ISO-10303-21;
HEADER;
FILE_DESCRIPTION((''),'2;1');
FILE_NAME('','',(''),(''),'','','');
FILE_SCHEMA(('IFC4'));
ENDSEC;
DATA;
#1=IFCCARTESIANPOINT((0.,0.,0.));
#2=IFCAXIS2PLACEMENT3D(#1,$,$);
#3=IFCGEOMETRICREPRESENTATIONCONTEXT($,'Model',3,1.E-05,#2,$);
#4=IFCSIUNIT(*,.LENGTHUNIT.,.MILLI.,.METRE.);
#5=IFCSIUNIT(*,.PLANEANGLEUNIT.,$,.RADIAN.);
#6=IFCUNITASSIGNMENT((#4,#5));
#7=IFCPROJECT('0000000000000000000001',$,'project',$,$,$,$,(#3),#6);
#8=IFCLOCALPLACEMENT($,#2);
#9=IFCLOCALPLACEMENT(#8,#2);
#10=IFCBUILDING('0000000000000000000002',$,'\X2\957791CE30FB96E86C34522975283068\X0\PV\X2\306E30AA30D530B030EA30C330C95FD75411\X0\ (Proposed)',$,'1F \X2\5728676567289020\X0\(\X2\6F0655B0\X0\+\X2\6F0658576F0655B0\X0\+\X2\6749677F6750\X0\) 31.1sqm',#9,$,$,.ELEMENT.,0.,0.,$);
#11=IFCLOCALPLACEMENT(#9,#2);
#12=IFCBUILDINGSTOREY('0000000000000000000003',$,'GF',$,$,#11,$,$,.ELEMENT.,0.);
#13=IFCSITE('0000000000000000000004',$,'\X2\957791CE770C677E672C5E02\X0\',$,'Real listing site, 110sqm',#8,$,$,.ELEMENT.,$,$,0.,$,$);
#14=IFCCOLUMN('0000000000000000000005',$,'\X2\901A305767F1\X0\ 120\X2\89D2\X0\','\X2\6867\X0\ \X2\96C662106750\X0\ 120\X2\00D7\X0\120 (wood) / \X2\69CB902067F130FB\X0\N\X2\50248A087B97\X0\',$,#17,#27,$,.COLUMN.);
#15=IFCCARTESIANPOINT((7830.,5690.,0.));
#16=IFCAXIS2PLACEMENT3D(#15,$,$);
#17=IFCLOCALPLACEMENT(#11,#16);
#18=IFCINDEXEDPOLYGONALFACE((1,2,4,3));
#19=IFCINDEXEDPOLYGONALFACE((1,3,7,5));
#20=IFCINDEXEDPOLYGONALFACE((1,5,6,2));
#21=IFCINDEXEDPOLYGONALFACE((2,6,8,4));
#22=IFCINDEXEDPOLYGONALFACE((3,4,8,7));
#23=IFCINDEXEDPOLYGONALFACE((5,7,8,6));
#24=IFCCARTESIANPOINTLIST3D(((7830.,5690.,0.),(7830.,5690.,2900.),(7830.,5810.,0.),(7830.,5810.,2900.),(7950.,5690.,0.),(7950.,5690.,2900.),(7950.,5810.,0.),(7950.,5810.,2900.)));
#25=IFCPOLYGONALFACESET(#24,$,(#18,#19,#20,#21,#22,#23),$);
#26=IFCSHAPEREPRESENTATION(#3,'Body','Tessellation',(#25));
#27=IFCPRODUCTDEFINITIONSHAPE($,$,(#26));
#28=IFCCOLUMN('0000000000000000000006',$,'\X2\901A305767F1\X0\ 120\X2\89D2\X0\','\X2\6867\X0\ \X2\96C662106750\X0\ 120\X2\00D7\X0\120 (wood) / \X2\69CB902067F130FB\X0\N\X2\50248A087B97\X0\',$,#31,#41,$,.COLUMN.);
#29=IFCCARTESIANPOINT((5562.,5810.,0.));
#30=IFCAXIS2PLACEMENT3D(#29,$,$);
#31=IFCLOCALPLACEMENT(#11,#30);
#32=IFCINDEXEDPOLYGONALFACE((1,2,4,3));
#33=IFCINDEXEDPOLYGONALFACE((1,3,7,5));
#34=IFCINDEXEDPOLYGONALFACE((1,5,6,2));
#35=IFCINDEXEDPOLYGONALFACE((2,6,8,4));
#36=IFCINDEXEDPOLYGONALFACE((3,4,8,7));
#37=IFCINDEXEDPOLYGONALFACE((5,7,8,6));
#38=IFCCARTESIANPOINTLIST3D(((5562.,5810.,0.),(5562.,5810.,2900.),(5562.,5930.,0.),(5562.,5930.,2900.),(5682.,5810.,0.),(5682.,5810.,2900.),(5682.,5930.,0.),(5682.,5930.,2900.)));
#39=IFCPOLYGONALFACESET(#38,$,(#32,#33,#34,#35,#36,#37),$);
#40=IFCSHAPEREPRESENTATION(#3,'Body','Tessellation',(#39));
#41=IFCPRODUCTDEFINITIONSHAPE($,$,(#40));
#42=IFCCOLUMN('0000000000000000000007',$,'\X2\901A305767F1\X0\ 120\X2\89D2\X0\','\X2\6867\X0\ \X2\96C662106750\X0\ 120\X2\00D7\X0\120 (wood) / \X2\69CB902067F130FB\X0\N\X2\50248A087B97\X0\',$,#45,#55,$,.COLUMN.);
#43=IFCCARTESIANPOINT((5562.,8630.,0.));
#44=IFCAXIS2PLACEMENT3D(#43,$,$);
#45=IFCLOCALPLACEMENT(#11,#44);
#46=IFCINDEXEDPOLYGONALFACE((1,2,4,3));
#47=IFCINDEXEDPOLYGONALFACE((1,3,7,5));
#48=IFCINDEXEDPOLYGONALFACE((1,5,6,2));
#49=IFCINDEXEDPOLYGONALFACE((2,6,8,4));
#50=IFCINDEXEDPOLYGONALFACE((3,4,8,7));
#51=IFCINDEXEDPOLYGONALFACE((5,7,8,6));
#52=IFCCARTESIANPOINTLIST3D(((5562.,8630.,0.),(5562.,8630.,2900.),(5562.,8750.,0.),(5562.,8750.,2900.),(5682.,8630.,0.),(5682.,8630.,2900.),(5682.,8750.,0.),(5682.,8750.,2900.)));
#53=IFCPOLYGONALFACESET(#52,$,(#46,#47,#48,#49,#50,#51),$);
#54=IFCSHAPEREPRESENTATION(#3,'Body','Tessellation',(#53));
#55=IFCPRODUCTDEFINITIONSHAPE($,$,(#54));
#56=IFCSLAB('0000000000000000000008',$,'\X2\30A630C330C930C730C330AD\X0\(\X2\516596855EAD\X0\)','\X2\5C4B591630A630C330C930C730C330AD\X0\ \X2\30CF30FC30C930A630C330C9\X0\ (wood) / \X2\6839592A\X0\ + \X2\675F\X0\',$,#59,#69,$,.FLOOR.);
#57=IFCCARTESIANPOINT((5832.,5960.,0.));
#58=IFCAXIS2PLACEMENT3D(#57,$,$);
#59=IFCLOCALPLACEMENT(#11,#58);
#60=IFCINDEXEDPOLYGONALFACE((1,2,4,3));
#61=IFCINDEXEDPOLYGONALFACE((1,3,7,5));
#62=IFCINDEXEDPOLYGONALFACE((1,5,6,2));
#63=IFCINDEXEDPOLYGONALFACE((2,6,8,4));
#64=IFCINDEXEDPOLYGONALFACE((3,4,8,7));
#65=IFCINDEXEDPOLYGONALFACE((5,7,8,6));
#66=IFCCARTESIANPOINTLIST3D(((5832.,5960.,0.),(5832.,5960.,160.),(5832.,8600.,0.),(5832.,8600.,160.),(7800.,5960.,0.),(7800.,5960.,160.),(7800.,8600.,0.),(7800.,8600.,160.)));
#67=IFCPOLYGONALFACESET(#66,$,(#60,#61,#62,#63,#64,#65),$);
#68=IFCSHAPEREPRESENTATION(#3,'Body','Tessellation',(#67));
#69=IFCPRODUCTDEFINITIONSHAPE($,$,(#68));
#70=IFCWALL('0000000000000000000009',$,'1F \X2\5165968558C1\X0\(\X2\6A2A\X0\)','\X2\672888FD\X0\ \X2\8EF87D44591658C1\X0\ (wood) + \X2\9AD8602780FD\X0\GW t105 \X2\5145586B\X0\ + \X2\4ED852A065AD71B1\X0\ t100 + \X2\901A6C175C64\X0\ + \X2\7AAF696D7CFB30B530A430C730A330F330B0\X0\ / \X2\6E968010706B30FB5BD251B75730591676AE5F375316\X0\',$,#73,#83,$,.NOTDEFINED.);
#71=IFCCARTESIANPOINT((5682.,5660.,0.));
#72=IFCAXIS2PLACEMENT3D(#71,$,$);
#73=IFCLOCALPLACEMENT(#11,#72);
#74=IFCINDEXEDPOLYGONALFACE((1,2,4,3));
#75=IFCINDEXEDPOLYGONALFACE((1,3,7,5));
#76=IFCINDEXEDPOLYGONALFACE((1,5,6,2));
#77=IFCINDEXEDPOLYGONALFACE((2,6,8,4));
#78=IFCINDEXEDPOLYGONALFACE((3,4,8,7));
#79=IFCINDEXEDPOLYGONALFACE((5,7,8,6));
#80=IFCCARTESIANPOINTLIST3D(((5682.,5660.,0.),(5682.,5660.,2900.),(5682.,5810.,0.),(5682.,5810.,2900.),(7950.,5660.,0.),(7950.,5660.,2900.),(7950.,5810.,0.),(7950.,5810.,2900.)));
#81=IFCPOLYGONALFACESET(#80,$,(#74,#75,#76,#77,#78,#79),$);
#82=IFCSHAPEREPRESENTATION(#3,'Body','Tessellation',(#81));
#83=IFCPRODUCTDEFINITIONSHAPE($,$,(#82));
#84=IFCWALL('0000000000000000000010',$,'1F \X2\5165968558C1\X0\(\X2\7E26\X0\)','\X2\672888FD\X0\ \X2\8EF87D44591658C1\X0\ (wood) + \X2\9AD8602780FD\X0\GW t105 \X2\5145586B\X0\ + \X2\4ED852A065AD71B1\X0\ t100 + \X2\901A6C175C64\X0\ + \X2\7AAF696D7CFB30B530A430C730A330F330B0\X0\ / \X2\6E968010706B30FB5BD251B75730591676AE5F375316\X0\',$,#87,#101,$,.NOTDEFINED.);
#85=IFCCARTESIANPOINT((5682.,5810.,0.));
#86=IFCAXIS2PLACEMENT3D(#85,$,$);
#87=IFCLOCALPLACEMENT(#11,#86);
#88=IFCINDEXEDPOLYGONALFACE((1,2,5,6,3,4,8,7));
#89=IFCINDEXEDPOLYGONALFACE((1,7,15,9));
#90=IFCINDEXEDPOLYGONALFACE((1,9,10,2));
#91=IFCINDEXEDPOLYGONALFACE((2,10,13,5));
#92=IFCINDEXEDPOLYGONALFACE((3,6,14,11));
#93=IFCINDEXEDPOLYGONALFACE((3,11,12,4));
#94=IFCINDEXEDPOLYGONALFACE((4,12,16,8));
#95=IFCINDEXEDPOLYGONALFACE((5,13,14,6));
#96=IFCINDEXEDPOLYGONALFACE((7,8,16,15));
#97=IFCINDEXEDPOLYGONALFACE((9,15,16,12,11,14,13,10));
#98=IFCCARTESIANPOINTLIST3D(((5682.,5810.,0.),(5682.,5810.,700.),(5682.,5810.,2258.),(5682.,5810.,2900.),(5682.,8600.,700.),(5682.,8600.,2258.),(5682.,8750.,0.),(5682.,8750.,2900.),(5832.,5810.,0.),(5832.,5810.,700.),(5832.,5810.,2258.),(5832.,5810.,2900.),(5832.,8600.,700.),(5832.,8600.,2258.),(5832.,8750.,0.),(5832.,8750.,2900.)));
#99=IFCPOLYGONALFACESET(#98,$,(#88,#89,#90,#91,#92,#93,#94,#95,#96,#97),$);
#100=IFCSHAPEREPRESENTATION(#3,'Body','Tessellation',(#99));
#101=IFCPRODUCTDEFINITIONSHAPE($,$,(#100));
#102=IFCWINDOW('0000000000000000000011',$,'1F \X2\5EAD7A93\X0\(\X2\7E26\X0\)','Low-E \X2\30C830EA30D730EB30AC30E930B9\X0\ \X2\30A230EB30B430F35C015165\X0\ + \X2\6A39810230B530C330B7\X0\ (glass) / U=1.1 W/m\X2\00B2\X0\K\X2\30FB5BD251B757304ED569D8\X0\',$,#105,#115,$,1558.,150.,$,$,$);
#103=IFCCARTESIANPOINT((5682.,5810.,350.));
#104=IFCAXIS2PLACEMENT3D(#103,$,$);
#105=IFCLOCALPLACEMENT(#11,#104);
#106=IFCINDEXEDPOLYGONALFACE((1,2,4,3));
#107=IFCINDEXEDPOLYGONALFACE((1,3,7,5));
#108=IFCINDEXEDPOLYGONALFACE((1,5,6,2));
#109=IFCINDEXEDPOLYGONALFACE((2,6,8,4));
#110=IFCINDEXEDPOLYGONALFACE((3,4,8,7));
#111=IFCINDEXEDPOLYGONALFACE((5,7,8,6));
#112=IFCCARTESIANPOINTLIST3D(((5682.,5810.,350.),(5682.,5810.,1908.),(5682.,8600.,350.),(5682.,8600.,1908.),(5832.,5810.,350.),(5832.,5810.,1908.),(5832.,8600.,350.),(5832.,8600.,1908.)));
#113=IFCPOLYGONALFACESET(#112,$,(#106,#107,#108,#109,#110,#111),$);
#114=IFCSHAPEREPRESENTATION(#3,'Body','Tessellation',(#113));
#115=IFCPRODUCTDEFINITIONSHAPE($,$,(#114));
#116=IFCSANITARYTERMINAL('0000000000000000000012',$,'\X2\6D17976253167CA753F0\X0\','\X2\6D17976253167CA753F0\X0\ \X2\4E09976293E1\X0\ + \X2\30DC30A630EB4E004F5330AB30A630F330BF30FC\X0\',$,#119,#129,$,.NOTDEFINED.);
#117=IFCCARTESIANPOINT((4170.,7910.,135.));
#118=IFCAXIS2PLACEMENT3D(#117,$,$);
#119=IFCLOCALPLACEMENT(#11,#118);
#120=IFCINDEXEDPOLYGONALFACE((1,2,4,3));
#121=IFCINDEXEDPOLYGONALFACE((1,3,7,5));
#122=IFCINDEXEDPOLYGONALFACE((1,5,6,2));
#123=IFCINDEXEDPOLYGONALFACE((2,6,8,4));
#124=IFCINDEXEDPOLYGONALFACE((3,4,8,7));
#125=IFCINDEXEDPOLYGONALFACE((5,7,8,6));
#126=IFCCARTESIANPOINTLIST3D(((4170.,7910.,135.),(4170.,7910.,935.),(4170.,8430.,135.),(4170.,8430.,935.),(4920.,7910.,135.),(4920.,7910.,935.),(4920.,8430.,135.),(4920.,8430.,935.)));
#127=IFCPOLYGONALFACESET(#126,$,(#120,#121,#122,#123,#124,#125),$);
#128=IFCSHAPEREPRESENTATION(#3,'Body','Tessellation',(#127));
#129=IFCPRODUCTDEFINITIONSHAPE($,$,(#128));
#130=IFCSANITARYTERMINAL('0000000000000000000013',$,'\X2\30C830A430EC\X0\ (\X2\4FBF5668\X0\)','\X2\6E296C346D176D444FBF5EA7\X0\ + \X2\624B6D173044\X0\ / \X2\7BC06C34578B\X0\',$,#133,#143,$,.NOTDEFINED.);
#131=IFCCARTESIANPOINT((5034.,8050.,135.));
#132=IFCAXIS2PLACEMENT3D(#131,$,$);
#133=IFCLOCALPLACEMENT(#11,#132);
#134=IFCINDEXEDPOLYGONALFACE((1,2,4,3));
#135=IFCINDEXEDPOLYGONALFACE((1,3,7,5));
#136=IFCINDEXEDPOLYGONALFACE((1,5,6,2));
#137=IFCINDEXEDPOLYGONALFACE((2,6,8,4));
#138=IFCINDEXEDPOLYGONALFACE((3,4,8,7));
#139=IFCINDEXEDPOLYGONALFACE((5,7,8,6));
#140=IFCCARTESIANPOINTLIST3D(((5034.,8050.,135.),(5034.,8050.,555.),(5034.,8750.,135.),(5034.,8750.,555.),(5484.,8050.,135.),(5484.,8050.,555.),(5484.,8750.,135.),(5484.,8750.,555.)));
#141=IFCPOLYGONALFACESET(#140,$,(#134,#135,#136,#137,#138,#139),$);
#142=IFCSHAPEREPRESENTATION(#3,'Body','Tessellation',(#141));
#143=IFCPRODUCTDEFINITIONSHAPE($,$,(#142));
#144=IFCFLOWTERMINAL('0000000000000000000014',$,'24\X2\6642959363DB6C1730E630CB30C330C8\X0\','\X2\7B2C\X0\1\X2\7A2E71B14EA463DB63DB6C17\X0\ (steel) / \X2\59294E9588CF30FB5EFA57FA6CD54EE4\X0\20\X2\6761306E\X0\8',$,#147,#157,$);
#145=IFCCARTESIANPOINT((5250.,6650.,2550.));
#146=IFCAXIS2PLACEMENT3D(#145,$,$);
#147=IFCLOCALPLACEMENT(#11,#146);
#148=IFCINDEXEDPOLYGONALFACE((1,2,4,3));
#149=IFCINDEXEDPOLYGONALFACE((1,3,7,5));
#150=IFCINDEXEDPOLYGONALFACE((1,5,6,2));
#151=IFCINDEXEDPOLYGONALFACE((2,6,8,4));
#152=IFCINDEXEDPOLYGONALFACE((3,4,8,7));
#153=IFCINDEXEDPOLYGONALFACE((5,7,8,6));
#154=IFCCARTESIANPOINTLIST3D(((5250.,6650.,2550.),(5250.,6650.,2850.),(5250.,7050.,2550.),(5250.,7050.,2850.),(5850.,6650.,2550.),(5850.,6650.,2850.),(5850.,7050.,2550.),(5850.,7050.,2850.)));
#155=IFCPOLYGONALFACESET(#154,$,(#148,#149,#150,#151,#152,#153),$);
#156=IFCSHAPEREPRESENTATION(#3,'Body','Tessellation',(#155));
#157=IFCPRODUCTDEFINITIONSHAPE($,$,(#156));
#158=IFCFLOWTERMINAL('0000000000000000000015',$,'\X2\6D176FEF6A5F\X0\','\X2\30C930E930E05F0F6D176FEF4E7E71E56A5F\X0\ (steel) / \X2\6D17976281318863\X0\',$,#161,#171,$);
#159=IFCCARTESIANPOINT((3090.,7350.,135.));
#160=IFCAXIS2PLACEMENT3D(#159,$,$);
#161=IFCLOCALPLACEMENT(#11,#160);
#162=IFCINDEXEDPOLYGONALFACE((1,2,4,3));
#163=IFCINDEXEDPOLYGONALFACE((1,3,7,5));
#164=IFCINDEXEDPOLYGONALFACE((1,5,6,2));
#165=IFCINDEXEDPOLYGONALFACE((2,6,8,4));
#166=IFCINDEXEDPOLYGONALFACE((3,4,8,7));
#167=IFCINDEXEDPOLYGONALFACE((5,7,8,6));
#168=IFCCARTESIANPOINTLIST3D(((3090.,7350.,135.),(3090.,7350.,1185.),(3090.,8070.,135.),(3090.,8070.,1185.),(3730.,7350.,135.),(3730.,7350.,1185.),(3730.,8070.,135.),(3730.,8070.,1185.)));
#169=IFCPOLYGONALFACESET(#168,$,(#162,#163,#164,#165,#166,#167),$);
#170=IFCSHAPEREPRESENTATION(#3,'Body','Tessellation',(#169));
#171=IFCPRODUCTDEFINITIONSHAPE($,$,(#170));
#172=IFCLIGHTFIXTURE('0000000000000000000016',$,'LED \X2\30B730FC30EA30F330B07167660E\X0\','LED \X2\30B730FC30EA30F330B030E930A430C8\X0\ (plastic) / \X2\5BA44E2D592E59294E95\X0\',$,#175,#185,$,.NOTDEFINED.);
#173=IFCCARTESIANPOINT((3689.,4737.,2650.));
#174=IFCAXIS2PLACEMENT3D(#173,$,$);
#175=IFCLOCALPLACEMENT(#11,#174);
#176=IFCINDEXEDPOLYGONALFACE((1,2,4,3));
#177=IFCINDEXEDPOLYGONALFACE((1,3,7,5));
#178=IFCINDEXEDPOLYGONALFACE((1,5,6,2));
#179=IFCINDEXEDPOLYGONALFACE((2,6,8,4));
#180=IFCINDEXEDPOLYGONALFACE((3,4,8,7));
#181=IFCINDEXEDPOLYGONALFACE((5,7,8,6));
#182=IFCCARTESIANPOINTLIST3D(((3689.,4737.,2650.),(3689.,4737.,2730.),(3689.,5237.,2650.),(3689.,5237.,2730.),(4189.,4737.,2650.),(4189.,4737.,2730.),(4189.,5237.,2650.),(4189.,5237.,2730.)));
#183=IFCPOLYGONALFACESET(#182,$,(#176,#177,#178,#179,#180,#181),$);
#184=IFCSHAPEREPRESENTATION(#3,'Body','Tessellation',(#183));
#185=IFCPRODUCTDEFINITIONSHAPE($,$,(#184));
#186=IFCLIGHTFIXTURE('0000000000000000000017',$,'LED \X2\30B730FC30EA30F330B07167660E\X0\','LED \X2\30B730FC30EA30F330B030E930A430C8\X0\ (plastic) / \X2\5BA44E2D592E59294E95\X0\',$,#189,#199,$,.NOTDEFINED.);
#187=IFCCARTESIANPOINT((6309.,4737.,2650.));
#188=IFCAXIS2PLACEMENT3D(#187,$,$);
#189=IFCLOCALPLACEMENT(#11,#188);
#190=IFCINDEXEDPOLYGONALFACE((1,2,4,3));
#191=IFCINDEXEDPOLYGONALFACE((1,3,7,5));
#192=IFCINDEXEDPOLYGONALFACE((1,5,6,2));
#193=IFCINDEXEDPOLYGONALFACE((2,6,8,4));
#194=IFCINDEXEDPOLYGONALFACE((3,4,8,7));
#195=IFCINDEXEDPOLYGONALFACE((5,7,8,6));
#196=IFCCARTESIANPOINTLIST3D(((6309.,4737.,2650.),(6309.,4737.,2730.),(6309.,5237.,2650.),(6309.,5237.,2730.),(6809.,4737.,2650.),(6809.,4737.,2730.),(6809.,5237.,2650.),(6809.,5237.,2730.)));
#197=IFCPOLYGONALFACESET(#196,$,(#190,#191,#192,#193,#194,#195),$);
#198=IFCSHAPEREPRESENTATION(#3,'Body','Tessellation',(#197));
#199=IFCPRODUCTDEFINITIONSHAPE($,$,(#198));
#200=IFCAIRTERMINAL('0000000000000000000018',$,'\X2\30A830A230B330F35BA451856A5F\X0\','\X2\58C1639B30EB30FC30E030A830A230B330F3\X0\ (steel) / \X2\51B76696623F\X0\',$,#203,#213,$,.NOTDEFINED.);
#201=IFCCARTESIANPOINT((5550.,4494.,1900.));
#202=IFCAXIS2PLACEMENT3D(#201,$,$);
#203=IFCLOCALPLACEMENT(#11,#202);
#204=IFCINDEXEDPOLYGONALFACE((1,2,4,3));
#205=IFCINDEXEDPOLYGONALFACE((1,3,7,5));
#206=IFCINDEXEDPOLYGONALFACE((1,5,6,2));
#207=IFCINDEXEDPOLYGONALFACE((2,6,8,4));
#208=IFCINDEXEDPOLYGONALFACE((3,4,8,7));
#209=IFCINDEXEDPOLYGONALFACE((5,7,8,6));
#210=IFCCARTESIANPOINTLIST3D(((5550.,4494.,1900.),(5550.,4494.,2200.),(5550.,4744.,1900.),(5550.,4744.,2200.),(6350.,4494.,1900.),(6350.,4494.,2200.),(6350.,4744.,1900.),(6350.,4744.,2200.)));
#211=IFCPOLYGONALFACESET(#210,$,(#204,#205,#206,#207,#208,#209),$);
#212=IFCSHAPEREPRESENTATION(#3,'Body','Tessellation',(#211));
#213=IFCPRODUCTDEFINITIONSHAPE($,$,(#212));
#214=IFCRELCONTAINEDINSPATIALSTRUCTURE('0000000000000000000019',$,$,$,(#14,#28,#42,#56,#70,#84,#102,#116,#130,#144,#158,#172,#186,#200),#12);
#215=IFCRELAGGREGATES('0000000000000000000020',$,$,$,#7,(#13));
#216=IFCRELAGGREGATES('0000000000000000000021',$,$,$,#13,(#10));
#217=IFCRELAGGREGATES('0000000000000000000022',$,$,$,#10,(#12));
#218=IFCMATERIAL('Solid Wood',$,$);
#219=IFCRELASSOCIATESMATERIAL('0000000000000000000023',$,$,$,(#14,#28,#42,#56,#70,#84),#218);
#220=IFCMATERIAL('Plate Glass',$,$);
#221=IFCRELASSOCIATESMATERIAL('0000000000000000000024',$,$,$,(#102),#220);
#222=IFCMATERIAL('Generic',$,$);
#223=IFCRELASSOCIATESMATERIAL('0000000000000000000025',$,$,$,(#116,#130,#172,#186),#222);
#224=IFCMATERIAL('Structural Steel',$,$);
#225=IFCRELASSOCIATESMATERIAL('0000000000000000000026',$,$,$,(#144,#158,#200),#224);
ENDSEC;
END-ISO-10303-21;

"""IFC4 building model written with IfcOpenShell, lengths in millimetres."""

from ifc_helpers import new_model, si_unit, frame, frame_2d, origin, place, context, project, spatial, rectangle, extrude, material, element, fill, save


model = new_model("IFC4")

# Units and contexts
model_context = context("Model", 3, precision=1e-05, world=origin())
ifc_project = project(units=[si_unit("LENGTHUNIT", "METRE", prefix="MILLI"), si_unit("PLANEANGLEUNIT", "RADIAN")], contexts=[model_context])

# Site, building, storey
site_placement = place(None, origin())
site = spatial("IfcSite", under=ifc_project, at=site_placement, Name="長野県松本市", ObjectType="Real listing site, 110sqm", CompositionType="ELEMENT", RefElevation=0.0)
building_placement = place(site_placement, origin())
building = spatial("IfcBuilding", under=site, at=building_placement, Name="長野・雨水利用とPVのオフグリッド志向 (Proposed)", ObjectType="1F 在来木造(漆喰+漆塗漆喰+杉板材) 31.1sqm", CompositionType="ELEMENT", ElevationOfRefHeight=0.0, ElevationOfTerrain=0.0)
storey_placement = place(building_placement, origin())
storey = spatial("IfcBuildingStorey", under=building, at=storey_placement, Name="GF", CompositionType="ELEMENT", Elevation=0.0)

# Columns
ifc_material_1 = material(Name="Solid Wood")
column_1_placement = place(storey_placement, frame((7830.0, 5690.0, 0.0)))
element("IfcColumn", 1, at=column_1_placement, inside=storey, material=ifc_material_1, Name="通し柱 120角", Description="桧 集成材 120×120 (wood) / 構造柱・N値計算", PredefinedType="COLUMN", context=model_context, shape_type="SweptSolid", body=[
    extrude(rectangle(XDim=120.0, YDim=120.0, at=frame_2d((60.0, 60.0))), frame((7830.0, 5690.0, 0.0)), (0.0, 0.0, 1.0), 2900.0),
])
column_2_placement = place(storey_placement, frame((5562.0, 5810.0, 0.0)))
element("IfcColumn", 2, at=column_2_placement, inside=storey, material=ifc_material_1, Name="通し柱 120角", Description="桧 集成材 120×120 (wood) / 構造柱・N値計算", PredefinedType="COLUMN", context=model_context, shape_type="SweptSolid", body=[
    extrude(rectangle(XDim=120.0, YDim=120.0, at=frame_2d((60.0, 60.0))), frame((5562.0, 5810.0, 0.0)), (0.0, 0.0, 1.0), 2900.0),
])
column_3_placement = place(storey_placement, frame((5562.0, 8630.0, 0.0)))
element("IfcColumn", 3, at=column_3_placement, inside=storey, material=ifc_material_1, Name="通し柱 120角", Description="桧 集成材 120×120 (wood) / 構造柱・N値計算", PredefinedType="COLUMN", context=model_context, shape_type="SweptSolid", body=[
    extrude(rectangle(XDim=120.0, YDim=120.0, at=frame_2d((60.0, 60.0))), frame((5562.0, 8630.0, 0.0)), (0.0, 0.0, 1.0), 2900.0),
])

# Slab
slab_placement = place(storey_placement, frame((5832.0, 5960.0, 0.0)))
element("IfcSlab", 4, at=slab_placement, inside=storey, material=ifc_material_1, Name="ウッドデッキ(入隅庭)", Description="屋外ウッドデッキ ハードウッド (wood) / 根太 + 束", PredefinedType="FLOOR", context=model_context, shape_type="SweptSolid", body=[
    extrude(rectangle(XDim=1968.0, YDim=2640.0, at=frame_2d((984.0, 1320.0))), frame((5832.0, 5960.0, 0.0)), (0.0, 0.0, 1.0), 160.0),
])

# Wall
wall_1_placement = place(storey_placement, frame((5682.0, 5660.0, 0.0)))
element("IfcWall", 5, at=wall_1_placement, inside=storey, material=ifc_material_1, Name="1F 入隅壁(横)", Description="木製 軸組外壁 (wood) + 高性能GW t105 充填 + 付加断熱 t100 + 通気層 + 窯業系サイディング / 準耐火・寒冷地外皮強化", PredefinedType="NOTDEFINED", context=model_context, shape_type="SweptSolid", body=[
    extrude(rectangle(XDim=2268.0, YDim=150.0, at=frame_2d((1134.0, 75.0))), frame((5682.0, 5660.0, 0.0)), (0.0, 0.0, 1.0), 2900.0),
])

# Wall, opening, window
wall_2_placement = place(storey_placement, frame((5682.0, 5810.0, 0.0)))
wall_2 = element("IfcWall", 6, at=wall_2_placement, inside=storey, material=ifc_material_1, Name="1F 入隅壁(縦)", Description="木製 軸組外壁 (wood) + 高性能GW t105 充填 + 付加断熱 t100 + 通気層 + 窯業系サイディング / 準耐火・寒冷地外皮強化", PredefinedType="NOTDEFINED", context=model_context, shape_type="SweptSolid", body=[
    extrude(rectangle(XDim=150.0, YDim=2940.0, at=frame_2d((75.0, 1470.0))), frame((5682.0, 5810.0, 0.0)), (0.0, 0.0, 1.0), 2900.0),
])
opening_placement = place(storey_placement, frame((5682.0, 5810.0, 350.0)))
opening = element("IfcOpeningElement", 7, at=opening_placement, cuts=wall_2, PredefinedType="NOTDEFINED", context=model_context, shape_type="SweptSolid", body=[
    extrude(rectangle(XDim=150.0, YDim=2790.0, at=frame_2d((75.0, 1395.0))), frame((5682.0, 5810.0, 350.0)), (0.0, 0.0, 1.0), 1558.0),
])
ifc_material_2 = material(Name="Plate Glass")
window_placement = place(storey_placement, frame((5682.0, 5810.0, 350.0)))
window = element("IfcWindow", 8, at=window_placement, inside=storey, material=ifc_material_2, Name="1F 庭窓(縦)", Description="Low-E トリプルガラス アルゴン封入 + 樹脂サッシ (glass) / U=1.1 W/m²K・寒冷地仕様", OverallHeight=1558.0, OverallWidth=150.0, context=model_context, shape_type="SweptSolid", body=[
    extrude(rectangle(XDim=150.0, YDim=2790.0, at=frame_2d((75.0, 1395.0))), frame((5682.0, 5810.0, 350.0)), (0.0, 0.0, 1.0), 1558.0),
])
fill(opening, window)

# Sanitary terminals
ifc_material_3 = material(Name="Generic")
sanitary_terminal_1_placement = place(storey_placement, frame((4170.0, 7910.0, 135.0)))
element("IfcSanitaryTerminal", 9, at=sanitary_terminal_1_placement, inside=storey, material=ifc_material_3, Name="洗面化粧台", Description="洗面化粧台 三面鏡 + ボウル一体カウンター", PredefinedType="NOTDEFINED", context=model_context, shape_type="SweptSolid", body=[
    extrude(rectangle(XDim=750.0, YDim=520.0, at=frame_2d((375.0, 260.0))), frame((4170.0, 7910.0, 135.0)), (0.0, 0.0, 1.0), 800.0),
])
sanitary_terminal_2_placement = place(storey_placement, frame((5034.0, 8050.0, 135.0)))
element("IfcSanitaryTerminal", 10, at=sanitary_terminal_2_placement, inside=storey, material=ifc_material_3, Name="トイレ (便器)", Description="温水洗浄便座 + 手洗い / 節水型", PredefinedType="NOTDEFINED", context=model_context, shape_type="SweptSolid", body=[
    extrude(rectangle(XDim=450.0, YDim=700.0, at=frame_2d((225.0, 350.0))), frame((5034.0, 8050.0, 135.0)), (0.0, 0.0, 1.0), 420.0),
])

# Flow terminals
ifc_material_4 = material(Name="Structural Steel")
flow_terminal_1_placement = place(storey_placement, frame((5250.0, 6650.0, 2550.0)))
element("IfcFlowTerminal", 11, at=flow_terminal_1_placement, inside=storey, material=ifc_material_4, Name="24時間換気ユニット", Description="第1種熱交換換気 (steel) / 天井裏・建基法令20条の8", context=model_context, shape_type="SweptSolid", body=[
    extrude(rectangle(XDim=600.0, YDim=400.0, at=frame_2d((300.0, 200.0))), frame((5250.0, 6650.0, 2550.0)), (0.0, 0.0, 1.0), 300.0),
])
flow_terminal_2_placement = place(storey_placement, frame((3090.0, 7350.0, 135.0)))
element("IfcFlowTerminal", 12, at=flow_terminal_2_placement, inside=storey, material=ifc_material_4, Name="洗濯機", Description="ドラム式洗濯乾燥機 (steel) / 洗面脱衣", context=model_context, shape_type="SweptSolid", body=[
    extrude(rectangle(XDim=640.0, YDim=720.0, at=frame_2d((320.0, 360.0))), frame((3090.0, 7350.0, 135.0)), (0.0, 0.0, 1.0), 1050.0),
])

# Light fixtures
light_fixture_1_placement = place(storey_placement, frame((3689.0, 4737.0, 2650.0)))
element("IfcLightFixture", 13, at=light_fixture_1_placement, inside=storey, material=ifc_material_3, Name="LED シーリング照明", Description="LED シーリングライト (plastic) / 室中央天井", PredefinedType="NOTDEFINED", context=model_context, shape_type="SweptSolid", body=[
    extrude(rectangle(XDim=500.0, YDim=500.0, at=frame_2d((250.0, 250.0))), frame((3689.0, 4737.0, 2650.0)), (0.0, 0.0, 1.0), 80.0),
])
light_fixture_2_placement = place(storey_placement, frame((6309.0, 4737.0, 2650.0)))
element("IfcLightFixture", 14, at=light_fixture_2_placement, inside=storey, material=ifc_material_3, Name="LED シーリング照明", Description="LED シーリングライト (plastic) / 室中央天井", PredefinedType="NOTDEFINED", context=model_context, shape_type="SweptSolid", body=[
    extrude(rectangle(XDim=500.0, YDim=500.0, at=frame_2d((250.0, 250.0))), frame((6309.0, 4737.0, 2650.0)), (0.0, 0.0, 1.0), 80.0),
])

# Air terminal
air_terminal_placement = place(storey_placement, frame((5550.0, 4494.0, 1900.0)))
element("IfcAirTerminal", 15, at=air_terminal_placement, inside=storey, material=ifc_material_4, Name="エアコン室内機", Description="壁掛ルームエアコン (steel) / 冷暖房", PredefinedType="NOTDEFINED", context=model_context, shape_type="SweptSolid", body=[
    extrude(rectangle(XDim=800.0, YDim=250.0, at=frame_2d((400.0, 125.0))), frame((5550.0, 4494.0, 1900.0)), (0.0, 0.0, 1.0), 300.0),
])

save(model, "model.ifc")
